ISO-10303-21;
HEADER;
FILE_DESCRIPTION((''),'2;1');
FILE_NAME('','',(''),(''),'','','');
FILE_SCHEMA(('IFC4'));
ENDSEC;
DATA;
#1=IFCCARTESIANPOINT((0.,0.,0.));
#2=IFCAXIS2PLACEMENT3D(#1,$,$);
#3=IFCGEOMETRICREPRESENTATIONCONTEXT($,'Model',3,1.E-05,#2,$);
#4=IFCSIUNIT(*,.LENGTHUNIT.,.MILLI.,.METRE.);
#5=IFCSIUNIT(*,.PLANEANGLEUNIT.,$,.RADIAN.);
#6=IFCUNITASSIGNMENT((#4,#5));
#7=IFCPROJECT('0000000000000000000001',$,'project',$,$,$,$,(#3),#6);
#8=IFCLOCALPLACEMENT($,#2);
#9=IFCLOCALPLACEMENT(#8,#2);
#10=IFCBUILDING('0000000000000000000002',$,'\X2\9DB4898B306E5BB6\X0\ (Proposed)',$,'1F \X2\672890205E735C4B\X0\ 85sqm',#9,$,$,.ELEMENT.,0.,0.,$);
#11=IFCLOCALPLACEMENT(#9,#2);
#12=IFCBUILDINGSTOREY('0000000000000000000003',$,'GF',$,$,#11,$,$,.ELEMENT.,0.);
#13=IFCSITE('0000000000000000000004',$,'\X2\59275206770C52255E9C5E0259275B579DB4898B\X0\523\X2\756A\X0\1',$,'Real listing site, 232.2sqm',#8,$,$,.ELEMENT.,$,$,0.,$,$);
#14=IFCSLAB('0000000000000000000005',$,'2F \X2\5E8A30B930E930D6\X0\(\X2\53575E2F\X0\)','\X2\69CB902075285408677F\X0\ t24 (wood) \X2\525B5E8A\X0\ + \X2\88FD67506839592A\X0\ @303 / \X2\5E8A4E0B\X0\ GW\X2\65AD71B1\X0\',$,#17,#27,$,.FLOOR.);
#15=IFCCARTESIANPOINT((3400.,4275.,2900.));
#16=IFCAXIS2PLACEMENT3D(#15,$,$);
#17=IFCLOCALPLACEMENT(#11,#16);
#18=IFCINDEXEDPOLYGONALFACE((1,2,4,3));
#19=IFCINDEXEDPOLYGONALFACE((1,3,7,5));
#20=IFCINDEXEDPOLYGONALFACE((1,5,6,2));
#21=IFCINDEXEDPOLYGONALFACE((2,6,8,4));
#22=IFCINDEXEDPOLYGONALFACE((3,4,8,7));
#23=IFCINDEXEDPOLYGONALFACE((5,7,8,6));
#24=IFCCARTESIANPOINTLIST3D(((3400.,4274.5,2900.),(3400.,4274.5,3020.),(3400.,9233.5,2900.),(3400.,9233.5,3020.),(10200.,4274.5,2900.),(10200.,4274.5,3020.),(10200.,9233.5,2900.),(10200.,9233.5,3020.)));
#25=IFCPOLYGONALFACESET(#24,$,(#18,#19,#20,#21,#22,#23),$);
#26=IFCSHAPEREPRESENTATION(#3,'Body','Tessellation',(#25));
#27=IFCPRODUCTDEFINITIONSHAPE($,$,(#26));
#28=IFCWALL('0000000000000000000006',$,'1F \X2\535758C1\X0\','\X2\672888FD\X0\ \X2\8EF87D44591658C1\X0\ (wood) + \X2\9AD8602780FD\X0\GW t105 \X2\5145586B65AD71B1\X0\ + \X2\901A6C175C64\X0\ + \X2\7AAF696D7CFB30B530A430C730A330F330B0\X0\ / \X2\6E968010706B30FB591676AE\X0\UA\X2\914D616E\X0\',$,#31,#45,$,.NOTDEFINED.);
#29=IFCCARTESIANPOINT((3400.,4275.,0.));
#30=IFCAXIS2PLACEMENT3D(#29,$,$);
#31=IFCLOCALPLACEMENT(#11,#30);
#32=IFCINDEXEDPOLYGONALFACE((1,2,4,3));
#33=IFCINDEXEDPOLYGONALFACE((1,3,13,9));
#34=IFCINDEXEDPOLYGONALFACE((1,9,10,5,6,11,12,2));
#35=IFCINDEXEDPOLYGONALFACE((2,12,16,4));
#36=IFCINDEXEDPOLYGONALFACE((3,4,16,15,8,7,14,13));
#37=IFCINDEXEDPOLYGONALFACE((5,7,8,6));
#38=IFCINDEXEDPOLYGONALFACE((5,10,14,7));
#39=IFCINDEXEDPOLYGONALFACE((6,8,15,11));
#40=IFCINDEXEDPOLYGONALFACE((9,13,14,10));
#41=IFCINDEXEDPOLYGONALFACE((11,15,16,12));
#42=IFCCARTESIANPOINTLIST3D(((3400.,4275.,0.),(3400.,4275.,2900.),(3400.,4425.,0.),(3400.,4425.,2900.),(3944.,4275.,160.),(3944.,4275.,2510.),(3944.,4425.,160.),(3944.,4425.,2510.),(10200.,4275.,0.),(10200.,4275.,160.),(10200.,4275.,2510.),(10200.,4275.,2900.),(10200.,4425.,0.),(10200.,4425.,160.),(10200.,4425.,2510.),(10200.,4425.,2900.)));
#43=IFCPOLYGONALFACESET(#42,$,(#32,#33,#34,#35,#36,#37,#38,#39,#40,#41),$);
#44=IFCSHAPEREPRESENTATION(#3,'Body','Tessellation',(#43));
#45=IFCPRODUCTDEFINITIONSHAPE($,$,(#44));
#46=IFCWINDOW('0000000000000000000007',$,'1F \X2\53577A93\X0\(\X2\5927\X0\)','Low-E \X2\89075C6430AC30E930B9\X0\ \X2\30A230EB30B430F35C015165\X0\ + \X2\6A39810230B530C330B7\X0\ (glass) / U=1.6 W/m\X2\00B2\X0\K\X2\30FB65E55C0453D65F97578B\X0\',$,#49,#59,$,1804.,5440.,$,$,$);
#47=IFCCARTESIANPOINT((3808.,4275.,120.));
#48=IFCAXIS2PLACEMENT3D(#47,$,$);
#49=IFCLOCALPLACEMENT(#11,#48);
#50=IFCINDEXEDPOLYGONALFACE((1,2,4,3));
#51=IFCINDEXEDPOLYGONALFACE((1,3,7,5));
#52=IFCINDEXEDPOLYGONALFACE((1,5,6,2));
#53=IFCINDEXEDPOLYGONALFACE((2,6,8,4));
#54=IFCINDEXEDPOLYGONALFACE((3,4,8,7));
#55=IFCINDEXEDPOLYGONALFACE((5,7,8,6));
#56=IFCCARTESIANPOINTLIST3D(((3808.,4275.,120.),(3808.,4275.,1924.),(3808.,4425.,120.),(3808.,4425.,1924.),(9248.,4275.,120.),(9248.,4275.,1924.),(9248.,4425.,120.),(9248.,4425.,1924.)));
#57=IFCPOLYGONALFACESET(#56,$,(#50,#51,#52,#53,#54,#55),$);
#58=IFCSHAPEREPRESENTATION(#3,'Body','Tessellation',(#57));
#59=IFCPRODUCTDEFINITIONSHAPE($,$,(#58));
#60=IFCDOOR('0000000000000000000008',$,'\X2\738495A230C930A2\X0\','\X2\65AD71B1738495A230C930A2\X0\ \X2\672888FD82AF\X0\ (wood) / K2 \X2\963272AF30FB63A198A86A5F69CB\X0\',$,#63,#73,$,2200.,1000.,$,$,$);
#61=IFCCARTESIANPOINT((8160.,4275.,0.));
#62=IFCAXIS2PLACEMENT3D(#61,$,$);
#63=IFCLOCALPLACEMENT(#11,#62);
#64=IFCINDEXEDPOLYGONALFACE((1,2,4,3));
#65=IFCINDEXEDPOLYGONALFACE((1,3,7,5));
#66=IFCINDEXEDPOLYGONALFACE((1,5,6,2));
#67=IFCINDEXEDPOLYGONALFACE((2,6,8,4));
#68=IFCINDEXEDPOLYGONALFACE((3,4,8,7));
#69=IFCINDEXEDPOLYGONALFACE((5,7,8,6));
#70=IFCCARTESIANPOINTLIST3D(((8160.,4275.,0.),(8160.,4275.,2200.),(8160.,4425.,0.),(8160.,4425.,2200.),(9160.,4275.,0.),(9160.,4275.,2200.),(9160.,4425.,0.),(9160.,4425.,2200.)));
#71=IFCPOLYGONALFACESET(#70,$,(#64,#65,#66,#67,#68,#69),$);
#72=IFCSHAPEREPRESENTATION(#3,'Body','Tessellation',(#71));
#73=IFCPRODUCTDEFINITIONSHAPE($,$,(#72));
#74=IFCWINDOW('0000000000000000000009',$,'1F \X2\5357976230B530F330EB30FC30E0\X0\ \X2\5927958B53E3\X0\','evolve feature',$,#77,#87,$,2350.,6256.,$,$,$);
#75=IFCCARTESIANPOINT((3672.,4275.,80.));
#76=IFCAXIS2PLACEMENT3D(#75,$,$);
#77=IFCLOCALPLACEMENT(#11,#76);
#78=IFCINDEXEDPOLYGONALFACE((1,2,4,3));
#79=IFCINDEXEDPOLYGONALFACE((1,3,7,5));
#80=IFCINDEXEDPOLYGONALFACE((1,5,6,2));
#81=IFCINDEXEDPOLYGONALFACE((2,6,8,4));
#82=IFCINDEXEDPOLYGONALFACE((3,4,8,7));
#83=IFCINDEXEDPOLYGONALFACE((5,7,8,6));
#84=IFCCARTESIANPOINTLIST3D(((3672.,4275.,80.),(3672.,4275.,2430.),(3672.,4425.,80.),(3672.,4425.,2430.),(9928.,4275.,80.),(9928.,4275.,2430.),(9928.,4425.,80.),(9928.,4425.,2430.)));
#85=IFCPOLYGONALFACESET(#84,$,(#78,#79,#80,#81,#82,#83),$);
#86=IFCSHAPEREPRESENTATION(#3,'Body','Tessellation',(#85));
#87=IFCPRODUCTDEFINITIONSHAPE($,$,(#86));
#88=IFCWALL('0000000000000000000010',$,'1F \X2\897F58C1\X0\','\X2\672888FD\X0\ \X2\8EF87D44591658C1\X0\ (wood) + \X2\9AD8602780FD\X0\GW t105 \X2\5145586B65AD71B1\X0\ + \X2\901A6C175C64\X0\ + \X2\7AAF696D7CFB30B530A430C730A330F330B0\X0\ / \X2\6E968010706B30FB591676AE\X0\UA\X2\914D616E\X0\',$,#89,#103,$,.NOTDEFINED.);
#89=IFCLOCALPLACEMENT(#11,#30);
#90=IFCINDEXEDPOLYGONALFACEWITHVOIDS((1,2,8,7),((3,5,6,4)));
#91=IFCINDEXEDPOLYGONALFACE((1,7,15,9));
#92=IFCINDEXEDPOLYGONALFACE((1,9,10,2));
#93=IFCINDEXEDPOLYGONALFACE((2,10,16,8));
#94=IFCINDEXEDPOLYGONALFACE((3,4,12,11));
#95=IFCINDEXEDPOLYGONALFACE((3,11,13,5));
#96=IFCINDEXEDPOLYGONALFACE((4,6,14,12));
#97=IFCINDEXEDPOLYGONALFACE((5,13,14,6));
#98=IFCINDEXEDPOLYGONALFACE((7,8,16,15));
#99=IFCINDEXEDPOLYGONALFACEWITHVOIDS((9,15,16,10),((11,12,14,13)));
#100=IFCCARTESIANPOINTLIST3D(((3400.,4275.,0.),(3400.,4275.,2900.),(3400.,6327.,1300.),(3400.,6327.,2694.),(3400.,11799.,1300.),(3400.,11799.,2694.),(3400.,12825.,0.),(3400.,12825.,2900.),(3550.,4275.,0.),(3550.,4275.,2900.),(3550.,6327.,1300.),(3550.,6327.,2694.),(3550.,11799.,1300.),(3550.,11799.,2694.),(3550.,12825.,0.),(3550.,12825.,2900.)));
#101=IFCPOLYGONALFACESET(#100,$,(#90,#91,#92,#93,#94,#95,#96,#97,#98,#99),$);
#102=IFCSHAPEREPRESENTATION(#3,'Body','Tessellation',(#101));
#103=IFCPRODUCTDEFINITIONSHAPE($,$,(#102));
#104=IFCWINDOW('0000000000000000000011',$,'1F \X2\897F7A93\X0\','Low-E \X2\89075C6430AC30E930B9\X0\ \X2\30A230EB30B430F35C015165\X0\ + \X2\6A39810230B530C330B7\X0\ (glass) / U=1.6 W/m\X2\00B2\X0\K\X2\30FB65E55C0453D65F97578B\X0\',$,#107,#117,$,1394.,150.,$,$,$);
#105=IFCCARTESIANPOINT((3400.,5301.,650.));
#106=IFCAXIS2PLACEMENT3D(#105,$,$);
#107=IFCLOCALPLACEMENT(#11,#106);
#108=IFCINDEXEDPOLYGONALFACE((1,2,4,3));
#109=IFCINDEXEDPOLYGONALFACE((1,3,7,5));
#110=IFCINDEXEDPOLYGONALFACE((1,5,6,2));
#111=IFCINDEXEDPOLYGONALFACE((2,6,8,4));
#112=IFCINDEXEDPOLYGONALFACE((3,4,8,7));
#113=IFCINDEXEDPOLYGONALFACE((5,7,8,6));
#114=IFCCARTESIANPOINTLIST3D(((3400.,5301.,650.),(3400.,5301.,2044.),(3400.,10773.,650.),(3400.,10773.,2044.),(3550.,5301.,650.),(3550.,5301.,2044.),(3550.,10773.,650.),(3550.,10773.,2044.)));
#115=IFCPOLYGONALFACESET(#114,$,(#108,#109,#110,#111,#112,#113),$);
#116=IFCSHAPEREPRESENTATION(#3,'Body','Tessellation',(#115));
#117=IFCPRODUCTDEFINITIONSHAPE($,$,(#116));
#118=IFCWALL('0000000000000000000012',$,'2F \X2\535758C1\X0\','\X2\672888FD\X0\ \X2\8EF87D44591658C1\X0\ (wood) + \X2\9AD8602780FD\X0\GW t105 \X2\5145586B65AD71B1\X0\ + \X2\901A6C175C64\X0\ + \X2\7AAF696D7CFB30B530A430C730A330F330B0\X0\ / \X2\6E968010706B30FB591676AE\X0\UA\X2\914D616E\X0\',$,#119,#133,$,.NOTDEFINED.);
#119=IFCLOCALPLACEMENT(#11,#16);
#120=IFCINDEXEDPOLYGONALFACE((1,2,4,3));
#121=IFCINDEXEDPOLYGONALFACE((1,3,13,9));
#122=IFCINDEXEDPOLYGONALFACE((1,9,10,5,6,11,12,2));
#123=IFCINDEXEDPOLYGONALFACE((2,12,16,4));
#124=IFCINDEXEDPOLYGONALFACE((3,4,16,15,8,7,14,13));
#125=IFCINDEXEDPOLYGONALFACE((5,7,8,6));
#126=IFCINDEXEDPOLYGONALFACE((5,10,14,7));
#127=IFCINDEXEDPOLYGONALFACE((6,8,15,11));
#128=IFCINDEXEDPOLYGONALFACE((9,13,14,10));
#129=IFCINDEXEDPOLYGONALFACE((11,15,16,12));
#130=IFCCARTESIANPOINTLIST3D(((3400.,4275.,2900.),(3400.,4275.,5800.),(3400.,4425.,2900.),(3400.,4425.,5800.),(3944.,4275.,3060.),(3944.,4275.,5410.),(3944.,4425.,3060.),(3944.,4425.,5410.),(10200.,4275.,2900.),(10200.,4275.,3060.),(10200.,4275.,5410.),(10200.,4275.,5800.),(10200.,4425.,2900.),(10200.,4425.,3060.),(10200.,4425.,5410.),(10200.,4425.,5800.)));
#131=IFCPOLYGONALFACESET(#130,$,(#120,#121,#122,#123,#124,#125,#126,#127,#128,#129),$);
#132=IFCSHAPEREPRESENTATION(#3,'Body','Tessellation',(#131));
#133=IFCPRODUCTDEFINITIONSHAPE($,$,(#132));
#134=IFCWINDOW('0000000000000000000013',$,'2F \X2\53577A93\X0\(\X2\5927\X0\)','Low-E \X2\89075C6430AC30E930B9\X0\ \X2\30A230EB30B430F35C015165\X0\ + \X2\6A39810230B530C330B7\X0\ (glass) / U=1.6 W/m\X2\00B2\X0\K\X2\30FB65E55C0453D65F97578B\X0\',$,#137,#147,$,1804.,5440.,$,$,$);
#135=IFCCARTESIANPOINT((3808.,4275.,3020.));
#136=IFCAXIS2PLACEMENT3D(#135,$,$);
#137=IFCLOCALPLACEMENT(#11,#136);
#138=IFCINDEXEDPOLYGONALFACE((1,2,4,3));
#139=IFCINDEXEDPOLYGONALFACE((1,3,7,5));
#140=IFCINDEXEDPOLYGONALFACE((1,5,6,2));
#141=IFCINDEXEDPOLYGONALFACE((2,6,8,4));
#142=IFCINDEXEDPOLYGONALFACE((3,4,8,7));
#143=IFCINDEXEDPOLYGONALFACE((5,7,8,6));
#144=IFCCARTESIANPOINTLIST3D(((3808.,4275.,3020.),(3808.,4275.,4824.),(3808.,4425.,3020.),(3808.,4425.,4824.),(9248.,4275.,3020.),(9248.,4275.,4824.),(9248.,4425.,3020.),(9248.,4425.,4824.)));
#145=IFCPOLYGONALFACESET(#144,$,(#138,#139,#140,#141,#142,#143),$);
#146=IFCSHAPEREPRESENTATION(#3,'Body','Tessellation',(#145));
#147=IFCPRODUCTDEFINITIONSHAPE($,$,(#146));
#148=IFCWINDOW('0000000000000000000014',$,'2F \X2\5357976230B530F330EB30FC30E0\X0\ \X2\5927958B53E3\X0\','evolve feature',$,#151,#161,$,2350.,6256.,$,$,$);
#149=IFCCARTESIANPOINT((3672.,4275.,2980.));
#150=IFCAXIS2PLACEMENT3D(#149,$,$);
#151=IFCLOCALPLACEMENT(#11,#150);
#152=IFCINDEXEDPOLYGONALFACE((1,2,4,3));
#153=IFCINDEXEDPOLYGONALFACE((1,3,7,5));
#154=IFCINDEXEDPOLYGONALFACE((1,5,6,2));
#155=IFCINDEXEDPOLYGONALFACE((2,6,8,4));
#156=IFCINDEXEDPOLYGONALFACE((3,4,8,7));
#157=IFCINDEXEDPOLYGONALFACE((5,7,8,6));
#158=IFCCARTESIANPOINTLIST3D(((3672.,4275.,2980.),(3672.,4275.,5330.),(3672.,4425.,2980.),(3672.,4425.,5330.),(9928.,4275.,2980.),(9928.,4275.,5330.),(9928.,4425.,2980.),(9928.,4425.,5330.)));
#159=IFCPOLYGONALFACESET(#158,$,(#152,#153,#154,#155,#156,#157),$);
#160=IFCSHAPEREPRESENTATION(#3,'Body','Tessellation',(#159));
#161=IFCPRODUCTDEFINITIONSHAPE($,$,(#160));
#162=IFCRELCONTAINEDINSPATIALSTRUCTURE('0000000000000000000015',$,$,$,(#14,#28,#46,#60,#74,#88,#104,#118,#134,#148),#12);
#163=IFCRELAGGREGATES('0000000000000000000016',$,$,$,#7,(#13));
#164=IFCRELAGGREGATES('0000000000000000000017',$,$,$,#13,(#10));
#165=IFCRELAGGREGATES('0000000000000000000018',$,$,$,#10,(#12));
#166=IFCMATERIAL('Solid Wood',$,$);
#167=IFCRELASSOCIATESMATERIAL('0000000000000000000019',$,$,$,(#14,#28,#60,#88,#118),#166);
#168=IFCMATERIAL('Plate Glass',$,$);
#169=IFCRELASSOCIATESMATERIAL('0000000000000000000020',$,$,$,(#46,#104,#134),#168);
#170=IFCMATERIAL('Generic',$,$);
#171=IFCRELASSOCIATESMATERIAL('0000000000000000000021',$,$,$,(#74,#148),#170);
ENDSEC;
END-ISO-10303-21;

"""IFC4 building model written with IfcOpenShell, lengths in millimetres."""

from ifc_helpers import new_model, si_unit, frame, frame_2d, origin, place, context, project, spatial, rectangle, extrude, material, element, fill, save


model = new_model("IFC4")

# Units and contexts
model_context = context("Model", 3, precision=1e-05, world=origin())
ifc_project = project(units=[si_unit("LENGTHUNIT", "METRE", prefix="MILLI"), si_unit("PLANEANGLEUNIT", "RADIAN")], contexts=[model_context])

# Site, building, storey
site_placement = place(None, origin())
site = spatial("IfcSite", under=ifc_project, at=site_placement, Name="大分県別府市大字鶴見523番1", ObjectType="Real listing site, 232.2sqm", CompositionType="ELEMENT", RefElevation=0.0)
building_placement = place(site_placement, origin())
building = spatial("IfcBuilding", under=site, at=building_placement, Name="鶴見の家 (Proposed)", ObjectType="1F 木造平屋 85sqm", CompositionType="ELEMENT", ElevationOfRefHeight=0.0, ElevationOfTerrain=0.0)
storey_placement = place(building_placement, origin())
storey = spatial("IfcBuildingStorey", under=building, at=storey_placement, Name="GF", CompositionType="ELEMENT", Elevation=0.0)

# Slab
ifc_material_1 = material(Name="Solid Wood")
slab_1_placement = place(storey_placement, frame((3400.0, 4275.0, 2900.0)))
element("IfcSlab", 1, at=slab_1_placement, inside=storey, material=ifc_material_1, Name="2F 床スラブ(南帯)", Description="構造用合板 t24 (wood) 剛床 + 製材根太 @303 / 床下 GW断熱", PredefinedType="FLOOR", context=model_context, shape_type="SweptSolid", body=[
    extrude(rectangle(XDim=6800.0, YDim=4959.0, at=frame_2d((3400.0, 2479.0))), frame((3400.0, 4275.0, 2900.0)), (0.0, 0.0, 1.0), 120.0),
])
ifc_material_2 = material(Name="Generic")

# Wall, openings, windows, door
wall_1_placement = place(storey_placement, frame((3400.0, 4275.0, 0.0)))
wall_1 = element("IfcWall", 2, at=wall_1_placement, inside=storey, material=ifc_material_1, Name="1F 南壁", Description="木製 軸組外壁 (wood) + 高性能GW t105 充填断熱 + 通気層 + 窯業系サイディング / 準耐火・外皮UA配慮", PredefinedType="NOTDEFINED", context=model_context, shape_type="SweptSolid", body=[
    extrude(rectangle(XDim=6800.0, YDim=150.0, at=frame_2d((3400.0, 75.0))), frame((3400.0, 4275.0, 0.0)), (0.0, 0.0, 1.0), 2900.0),
])
opening_1_placement = place(storey_placement, frame((3808.0, 4275.0, 120.0)))
opening_1 = element("IfcOpeningElement", 3, at=opening_1_placement, cuts=wall_1, PredefinedType="NOTDEFINED", context=model_context, shape_type="SweptSolid", body=[
    extrude(rectangle(XDim=5440.0, YDim=150.0, at=frame_2d((2720.0, 75.0))), frame((3808.0, 4275.0, 120.0)), (0.0, 0.0, 1.0), 1804.0),
])
opening_2_placement = place(storey_placement, frame((8160.0, 4275.0, 0.0)))
opening_2 = element("IfcOpeningElement", 4, at=opening_2_placement, cuts=wall_1, PredefinedType="NOTDEFINED", context=model_context, shape_type="SweptSolid", body=[
    extrude(rectangle(XDim=1000.0, YDim=150.0, at=frame_2d((500.0, 75.0))), frame((8160.0, 4275.0, 0.0)), (0.0, 0.0, 1.0), 2200.0),
])
opening_3_placement = place(storey_placement, frame((3672.0, 4275.0, 80.0)))
opening_3 = element("IfcOpeningElement", 5, at=opening_3_placement, cuts=wall_1, PredefinedType="NOTDEFINED", context=model_context, shape_type="SweptSolid", body=[
    extrude(rectangle(XDim=6256.0, YDim=150.0, at=frame_2d((3128.0, 75.0))), frame((3672.0, 4275.0, 80.0)), (0.0, 0.0, 1.0), 2350.0),
])
ifc_material_3 = material(Name="Plate Glass")
window_1_placement = place(storey_placement, frame((3808.0, 4275.0, 120.0)))
window_1 = element("IfcWindow", 6, at=window_1_placement, inside=storey, material=ifc_material_3, Name="1F 南窓(大)", Description="Low-E 複層ガラス アルゴン封入 + 樹脂サッシ (glass) / U=1.6 W/m²K・日射取得型", OverallHeight=1804.0, OverallWidth=5440.0, context=model_context, shape_type="SweptSolid", body=[
    extrude(rectangle(XDim=5440.0, YDim=150.0, at=frame_2d((2720.0, 75.0))), frame((3808.0, 4275.0, 120.0)), (0.0, 0.0, 1.0), 1804.0),
])
fill(opening_1, window_1)
door_placement = place(storey_placement, frame((8160.0, 4275.0, 0.0)))
door = element("IfcDoor", 7, at=door_placement, inside=storey, material=ifc_material_1, Name="玄関ドア", Description="断熱玄関ドア 木製芯 (wood) / K2 防犯・採風機構", OverallHeight=2200.0, OverallWidth=1000.0, context=model_context, shape_type="SweptSolid", body=[
    extrude(rectangle(XDim=1000.0, YDim=150.0, at=frame_2d((500.0, 75.0))), frame((8160.0, 4275.0, 0.0)), (0.0, 0.0, 1.0), 2200.0),
])
fill(opening_2, door)
window_2_placement = place(storey_placement, frame((3672.0, 4275.0, 80.0)))
window_2 = element("IfcWindow", 8, at=window_2_placement, inside=storey, material=ifc_material_2, Name="1F 南面サンルーム 大開口", Description="evolve feature", OverallHeight=2350.0, OverallWidth=6256.0, context=model_context, shape_type="SweptSolid", body=[
    extrude(rectangle(XDim=6256.0, YDim=150.0, at=frame_2d((3128.0, 75.0))), frame((3672.0, 4275.0, 80.0)), (0.0, 0.0, 1.0), 2350.0),
])
fill(opening_3, window_2)

# Wall, opening, window
wall_2_placement = place(storey_placement, frame((3400.0, 4275.0, 0.0)))
wall_2 = element("IfcWall", 9, at=wall_2_placement, inside=storey, material=ifc_material_1, Name="1F 西壁", Description="木製 軸組外壁 (wood) + 高性能GW t105 充填断熱 + 通気層 + 窯業系サイディング / 準耐火・外皮UA配慮", PredefinedType="NOTDEFINED", context=model_context, shape_type="SweptSolid", body=[
    extrude(rectangle(XDim=150.0, YDim=8550.0, at=frame_2d((75.0, 4275.0))), frame((3400.0, 4275.0, 0.0)), (0.0, 0.0, 1.0), 2900.0),
])
opening_4_placement = place(storey_placement, frame((3400.0, 5301.0, 650.0)))
opening_4 = element("IfcOpeningElement", 10, at=opening_4_placement, cuts=wall_2, PredefinedType="NOTDEFINED", context=model_context, shape_type="SweptSolid", body=[
    extrude(rectangle(XDim=150.0, YDim=5472.0, at=frame_2d((75.0, 2736.0))), frame((3400.0, 5301.0, 650.0)), (0.0, 0.0, 1.0), 1394.0),
])
window_3_placement = place(storey_placement, frame((3400.0, 5301.0, 650.0)))
window_3 = element("IfcWindow", 11, at=window_3_placement, inside=storey, material=ifc_material_3, Name="1F 西窓", Description="Low-E 複層ガラス アルゴン封入 + 樹脂サッシ (glass) / U=1.6 W/m²K・日射取得型", OverallHeight=1394.0, OverallWidth=150.0, context=model_context, shape_type="SweptSolid", body=[
    extrude(rectangle(XDim=150.0, YDim=5472.0, at=frame_2d((75.0, 2736.0))), frame((3400.0, 5301.0, 650.0)), (0.0, 0.0, 1.0), 1394.0),
])
fill(opening_4, window_3)

# Wall, openings, windows
wall_3_placement = place(storey_placement, frame((3400.0, 4275.0, 2900.0)))
wall_3 = element("IfcWall", 12, at=wall_3_placement, inside=storey, material=ifc_material_1, Name="2F 南壁", Description="木製 軸組外壁 (wood) + 高性能GW t105 充填断熱 + 通気層 + 窯業系サイディング / 準耐火・外皮UA配慮", PredefinedType="NOTDEFINED", context=model_context, shape_type="SweptSolid", body=[
    extrude(rectangle(XDim=6800.0, YDim=150.0, at=frame_2d((3400.0, 75.0))), frame((3400.0, 4275.0, 2900.0)), (0.0, 0.0, 1.0), 2900.0),
])
opening_5_placement = place(storey_placement, frame((3808.0, 4275.0, 3020.0)))
opening_5 = element("IfcOpeningElement", 13, at=opening_5_placement, cuts=wall_3, PredefinedType="NOTDEFINED", context=model_context, shape_type="SweptSolid", body=[
    extrude(rectangle(XDim=5440.0, YDim=150.0, at=frame_2d((2720.0, 75.0))), frame((3808.0, 4275.0, 3020.0)), (0.0, 0.0, 1.0), 1804.0),
])
opening_6_placement = place(storey_placement, frame((3672.0, 4275.0, 2980.0)))
opening_6 = element("IfcOpeningElement", 14, at=opening_6_placement, cuts=wall_3, PredefinedType="NOTDEFINED", context=model_context, shape_type="SweptSolid", body=[
    extrude(rectangle(XDim=6256.0, YDim=150.0, at=frame_2d((3128.0, 75.0))), frame((3672.0, 4275.0, 2980.0)), (0.0, 0.0, 1.0), 2350.0),
])
window_4_placement = place(storey_placement, frame((3808.0, 4275.0, 3020.0)))
window_4 = element("IfcWindow", 15, at=window_4_placement, inside=storey, material=ifc_material_3, Name="2F 南窓(大)", Description="Low-E 複層ガラス アルゴン封入 + 樹脂サッシ (glass) / U=1.6 W/m²K・日射取得型", OverallHeight=1804.0, OverallWidth=5440.0, context=model_context, shape_type="SweptSolid", body=[
    extrude(rectangle(XDim=5440.0, YDim=150.0, at=frame_2d((2720.0, 75.0))), frame((3808.0, 4275.0, 3020.0)), (0.0, 0.0, 1.0), 1804.0),
])
fill(opening_5, window_4)
window_5_placement = place(storey_placement, frame((3672.0, 4275.0, 2980.0)))
window_5 = element("IfcWindow", 16, at=window_5_placement, inside=storey, material=ifc_material_2, Name="2F 南面サンルーム 大開口", Description="evolve feature", OverallHeight=2350.0, OverallWidth=6256.0, context=model_context, shape_type="SweptSolid", body=[
    extrude(rectangle(XDim=6256.0, YDim=150.0, at=frame_2d((3128.0, 75.0))), frame((3672.0, 4275.0, 2980.0)), (0.0, 0.0, 1.0), 2350.0),
])
fill(opening_6, window_5)

save(model, "model.ifc")
